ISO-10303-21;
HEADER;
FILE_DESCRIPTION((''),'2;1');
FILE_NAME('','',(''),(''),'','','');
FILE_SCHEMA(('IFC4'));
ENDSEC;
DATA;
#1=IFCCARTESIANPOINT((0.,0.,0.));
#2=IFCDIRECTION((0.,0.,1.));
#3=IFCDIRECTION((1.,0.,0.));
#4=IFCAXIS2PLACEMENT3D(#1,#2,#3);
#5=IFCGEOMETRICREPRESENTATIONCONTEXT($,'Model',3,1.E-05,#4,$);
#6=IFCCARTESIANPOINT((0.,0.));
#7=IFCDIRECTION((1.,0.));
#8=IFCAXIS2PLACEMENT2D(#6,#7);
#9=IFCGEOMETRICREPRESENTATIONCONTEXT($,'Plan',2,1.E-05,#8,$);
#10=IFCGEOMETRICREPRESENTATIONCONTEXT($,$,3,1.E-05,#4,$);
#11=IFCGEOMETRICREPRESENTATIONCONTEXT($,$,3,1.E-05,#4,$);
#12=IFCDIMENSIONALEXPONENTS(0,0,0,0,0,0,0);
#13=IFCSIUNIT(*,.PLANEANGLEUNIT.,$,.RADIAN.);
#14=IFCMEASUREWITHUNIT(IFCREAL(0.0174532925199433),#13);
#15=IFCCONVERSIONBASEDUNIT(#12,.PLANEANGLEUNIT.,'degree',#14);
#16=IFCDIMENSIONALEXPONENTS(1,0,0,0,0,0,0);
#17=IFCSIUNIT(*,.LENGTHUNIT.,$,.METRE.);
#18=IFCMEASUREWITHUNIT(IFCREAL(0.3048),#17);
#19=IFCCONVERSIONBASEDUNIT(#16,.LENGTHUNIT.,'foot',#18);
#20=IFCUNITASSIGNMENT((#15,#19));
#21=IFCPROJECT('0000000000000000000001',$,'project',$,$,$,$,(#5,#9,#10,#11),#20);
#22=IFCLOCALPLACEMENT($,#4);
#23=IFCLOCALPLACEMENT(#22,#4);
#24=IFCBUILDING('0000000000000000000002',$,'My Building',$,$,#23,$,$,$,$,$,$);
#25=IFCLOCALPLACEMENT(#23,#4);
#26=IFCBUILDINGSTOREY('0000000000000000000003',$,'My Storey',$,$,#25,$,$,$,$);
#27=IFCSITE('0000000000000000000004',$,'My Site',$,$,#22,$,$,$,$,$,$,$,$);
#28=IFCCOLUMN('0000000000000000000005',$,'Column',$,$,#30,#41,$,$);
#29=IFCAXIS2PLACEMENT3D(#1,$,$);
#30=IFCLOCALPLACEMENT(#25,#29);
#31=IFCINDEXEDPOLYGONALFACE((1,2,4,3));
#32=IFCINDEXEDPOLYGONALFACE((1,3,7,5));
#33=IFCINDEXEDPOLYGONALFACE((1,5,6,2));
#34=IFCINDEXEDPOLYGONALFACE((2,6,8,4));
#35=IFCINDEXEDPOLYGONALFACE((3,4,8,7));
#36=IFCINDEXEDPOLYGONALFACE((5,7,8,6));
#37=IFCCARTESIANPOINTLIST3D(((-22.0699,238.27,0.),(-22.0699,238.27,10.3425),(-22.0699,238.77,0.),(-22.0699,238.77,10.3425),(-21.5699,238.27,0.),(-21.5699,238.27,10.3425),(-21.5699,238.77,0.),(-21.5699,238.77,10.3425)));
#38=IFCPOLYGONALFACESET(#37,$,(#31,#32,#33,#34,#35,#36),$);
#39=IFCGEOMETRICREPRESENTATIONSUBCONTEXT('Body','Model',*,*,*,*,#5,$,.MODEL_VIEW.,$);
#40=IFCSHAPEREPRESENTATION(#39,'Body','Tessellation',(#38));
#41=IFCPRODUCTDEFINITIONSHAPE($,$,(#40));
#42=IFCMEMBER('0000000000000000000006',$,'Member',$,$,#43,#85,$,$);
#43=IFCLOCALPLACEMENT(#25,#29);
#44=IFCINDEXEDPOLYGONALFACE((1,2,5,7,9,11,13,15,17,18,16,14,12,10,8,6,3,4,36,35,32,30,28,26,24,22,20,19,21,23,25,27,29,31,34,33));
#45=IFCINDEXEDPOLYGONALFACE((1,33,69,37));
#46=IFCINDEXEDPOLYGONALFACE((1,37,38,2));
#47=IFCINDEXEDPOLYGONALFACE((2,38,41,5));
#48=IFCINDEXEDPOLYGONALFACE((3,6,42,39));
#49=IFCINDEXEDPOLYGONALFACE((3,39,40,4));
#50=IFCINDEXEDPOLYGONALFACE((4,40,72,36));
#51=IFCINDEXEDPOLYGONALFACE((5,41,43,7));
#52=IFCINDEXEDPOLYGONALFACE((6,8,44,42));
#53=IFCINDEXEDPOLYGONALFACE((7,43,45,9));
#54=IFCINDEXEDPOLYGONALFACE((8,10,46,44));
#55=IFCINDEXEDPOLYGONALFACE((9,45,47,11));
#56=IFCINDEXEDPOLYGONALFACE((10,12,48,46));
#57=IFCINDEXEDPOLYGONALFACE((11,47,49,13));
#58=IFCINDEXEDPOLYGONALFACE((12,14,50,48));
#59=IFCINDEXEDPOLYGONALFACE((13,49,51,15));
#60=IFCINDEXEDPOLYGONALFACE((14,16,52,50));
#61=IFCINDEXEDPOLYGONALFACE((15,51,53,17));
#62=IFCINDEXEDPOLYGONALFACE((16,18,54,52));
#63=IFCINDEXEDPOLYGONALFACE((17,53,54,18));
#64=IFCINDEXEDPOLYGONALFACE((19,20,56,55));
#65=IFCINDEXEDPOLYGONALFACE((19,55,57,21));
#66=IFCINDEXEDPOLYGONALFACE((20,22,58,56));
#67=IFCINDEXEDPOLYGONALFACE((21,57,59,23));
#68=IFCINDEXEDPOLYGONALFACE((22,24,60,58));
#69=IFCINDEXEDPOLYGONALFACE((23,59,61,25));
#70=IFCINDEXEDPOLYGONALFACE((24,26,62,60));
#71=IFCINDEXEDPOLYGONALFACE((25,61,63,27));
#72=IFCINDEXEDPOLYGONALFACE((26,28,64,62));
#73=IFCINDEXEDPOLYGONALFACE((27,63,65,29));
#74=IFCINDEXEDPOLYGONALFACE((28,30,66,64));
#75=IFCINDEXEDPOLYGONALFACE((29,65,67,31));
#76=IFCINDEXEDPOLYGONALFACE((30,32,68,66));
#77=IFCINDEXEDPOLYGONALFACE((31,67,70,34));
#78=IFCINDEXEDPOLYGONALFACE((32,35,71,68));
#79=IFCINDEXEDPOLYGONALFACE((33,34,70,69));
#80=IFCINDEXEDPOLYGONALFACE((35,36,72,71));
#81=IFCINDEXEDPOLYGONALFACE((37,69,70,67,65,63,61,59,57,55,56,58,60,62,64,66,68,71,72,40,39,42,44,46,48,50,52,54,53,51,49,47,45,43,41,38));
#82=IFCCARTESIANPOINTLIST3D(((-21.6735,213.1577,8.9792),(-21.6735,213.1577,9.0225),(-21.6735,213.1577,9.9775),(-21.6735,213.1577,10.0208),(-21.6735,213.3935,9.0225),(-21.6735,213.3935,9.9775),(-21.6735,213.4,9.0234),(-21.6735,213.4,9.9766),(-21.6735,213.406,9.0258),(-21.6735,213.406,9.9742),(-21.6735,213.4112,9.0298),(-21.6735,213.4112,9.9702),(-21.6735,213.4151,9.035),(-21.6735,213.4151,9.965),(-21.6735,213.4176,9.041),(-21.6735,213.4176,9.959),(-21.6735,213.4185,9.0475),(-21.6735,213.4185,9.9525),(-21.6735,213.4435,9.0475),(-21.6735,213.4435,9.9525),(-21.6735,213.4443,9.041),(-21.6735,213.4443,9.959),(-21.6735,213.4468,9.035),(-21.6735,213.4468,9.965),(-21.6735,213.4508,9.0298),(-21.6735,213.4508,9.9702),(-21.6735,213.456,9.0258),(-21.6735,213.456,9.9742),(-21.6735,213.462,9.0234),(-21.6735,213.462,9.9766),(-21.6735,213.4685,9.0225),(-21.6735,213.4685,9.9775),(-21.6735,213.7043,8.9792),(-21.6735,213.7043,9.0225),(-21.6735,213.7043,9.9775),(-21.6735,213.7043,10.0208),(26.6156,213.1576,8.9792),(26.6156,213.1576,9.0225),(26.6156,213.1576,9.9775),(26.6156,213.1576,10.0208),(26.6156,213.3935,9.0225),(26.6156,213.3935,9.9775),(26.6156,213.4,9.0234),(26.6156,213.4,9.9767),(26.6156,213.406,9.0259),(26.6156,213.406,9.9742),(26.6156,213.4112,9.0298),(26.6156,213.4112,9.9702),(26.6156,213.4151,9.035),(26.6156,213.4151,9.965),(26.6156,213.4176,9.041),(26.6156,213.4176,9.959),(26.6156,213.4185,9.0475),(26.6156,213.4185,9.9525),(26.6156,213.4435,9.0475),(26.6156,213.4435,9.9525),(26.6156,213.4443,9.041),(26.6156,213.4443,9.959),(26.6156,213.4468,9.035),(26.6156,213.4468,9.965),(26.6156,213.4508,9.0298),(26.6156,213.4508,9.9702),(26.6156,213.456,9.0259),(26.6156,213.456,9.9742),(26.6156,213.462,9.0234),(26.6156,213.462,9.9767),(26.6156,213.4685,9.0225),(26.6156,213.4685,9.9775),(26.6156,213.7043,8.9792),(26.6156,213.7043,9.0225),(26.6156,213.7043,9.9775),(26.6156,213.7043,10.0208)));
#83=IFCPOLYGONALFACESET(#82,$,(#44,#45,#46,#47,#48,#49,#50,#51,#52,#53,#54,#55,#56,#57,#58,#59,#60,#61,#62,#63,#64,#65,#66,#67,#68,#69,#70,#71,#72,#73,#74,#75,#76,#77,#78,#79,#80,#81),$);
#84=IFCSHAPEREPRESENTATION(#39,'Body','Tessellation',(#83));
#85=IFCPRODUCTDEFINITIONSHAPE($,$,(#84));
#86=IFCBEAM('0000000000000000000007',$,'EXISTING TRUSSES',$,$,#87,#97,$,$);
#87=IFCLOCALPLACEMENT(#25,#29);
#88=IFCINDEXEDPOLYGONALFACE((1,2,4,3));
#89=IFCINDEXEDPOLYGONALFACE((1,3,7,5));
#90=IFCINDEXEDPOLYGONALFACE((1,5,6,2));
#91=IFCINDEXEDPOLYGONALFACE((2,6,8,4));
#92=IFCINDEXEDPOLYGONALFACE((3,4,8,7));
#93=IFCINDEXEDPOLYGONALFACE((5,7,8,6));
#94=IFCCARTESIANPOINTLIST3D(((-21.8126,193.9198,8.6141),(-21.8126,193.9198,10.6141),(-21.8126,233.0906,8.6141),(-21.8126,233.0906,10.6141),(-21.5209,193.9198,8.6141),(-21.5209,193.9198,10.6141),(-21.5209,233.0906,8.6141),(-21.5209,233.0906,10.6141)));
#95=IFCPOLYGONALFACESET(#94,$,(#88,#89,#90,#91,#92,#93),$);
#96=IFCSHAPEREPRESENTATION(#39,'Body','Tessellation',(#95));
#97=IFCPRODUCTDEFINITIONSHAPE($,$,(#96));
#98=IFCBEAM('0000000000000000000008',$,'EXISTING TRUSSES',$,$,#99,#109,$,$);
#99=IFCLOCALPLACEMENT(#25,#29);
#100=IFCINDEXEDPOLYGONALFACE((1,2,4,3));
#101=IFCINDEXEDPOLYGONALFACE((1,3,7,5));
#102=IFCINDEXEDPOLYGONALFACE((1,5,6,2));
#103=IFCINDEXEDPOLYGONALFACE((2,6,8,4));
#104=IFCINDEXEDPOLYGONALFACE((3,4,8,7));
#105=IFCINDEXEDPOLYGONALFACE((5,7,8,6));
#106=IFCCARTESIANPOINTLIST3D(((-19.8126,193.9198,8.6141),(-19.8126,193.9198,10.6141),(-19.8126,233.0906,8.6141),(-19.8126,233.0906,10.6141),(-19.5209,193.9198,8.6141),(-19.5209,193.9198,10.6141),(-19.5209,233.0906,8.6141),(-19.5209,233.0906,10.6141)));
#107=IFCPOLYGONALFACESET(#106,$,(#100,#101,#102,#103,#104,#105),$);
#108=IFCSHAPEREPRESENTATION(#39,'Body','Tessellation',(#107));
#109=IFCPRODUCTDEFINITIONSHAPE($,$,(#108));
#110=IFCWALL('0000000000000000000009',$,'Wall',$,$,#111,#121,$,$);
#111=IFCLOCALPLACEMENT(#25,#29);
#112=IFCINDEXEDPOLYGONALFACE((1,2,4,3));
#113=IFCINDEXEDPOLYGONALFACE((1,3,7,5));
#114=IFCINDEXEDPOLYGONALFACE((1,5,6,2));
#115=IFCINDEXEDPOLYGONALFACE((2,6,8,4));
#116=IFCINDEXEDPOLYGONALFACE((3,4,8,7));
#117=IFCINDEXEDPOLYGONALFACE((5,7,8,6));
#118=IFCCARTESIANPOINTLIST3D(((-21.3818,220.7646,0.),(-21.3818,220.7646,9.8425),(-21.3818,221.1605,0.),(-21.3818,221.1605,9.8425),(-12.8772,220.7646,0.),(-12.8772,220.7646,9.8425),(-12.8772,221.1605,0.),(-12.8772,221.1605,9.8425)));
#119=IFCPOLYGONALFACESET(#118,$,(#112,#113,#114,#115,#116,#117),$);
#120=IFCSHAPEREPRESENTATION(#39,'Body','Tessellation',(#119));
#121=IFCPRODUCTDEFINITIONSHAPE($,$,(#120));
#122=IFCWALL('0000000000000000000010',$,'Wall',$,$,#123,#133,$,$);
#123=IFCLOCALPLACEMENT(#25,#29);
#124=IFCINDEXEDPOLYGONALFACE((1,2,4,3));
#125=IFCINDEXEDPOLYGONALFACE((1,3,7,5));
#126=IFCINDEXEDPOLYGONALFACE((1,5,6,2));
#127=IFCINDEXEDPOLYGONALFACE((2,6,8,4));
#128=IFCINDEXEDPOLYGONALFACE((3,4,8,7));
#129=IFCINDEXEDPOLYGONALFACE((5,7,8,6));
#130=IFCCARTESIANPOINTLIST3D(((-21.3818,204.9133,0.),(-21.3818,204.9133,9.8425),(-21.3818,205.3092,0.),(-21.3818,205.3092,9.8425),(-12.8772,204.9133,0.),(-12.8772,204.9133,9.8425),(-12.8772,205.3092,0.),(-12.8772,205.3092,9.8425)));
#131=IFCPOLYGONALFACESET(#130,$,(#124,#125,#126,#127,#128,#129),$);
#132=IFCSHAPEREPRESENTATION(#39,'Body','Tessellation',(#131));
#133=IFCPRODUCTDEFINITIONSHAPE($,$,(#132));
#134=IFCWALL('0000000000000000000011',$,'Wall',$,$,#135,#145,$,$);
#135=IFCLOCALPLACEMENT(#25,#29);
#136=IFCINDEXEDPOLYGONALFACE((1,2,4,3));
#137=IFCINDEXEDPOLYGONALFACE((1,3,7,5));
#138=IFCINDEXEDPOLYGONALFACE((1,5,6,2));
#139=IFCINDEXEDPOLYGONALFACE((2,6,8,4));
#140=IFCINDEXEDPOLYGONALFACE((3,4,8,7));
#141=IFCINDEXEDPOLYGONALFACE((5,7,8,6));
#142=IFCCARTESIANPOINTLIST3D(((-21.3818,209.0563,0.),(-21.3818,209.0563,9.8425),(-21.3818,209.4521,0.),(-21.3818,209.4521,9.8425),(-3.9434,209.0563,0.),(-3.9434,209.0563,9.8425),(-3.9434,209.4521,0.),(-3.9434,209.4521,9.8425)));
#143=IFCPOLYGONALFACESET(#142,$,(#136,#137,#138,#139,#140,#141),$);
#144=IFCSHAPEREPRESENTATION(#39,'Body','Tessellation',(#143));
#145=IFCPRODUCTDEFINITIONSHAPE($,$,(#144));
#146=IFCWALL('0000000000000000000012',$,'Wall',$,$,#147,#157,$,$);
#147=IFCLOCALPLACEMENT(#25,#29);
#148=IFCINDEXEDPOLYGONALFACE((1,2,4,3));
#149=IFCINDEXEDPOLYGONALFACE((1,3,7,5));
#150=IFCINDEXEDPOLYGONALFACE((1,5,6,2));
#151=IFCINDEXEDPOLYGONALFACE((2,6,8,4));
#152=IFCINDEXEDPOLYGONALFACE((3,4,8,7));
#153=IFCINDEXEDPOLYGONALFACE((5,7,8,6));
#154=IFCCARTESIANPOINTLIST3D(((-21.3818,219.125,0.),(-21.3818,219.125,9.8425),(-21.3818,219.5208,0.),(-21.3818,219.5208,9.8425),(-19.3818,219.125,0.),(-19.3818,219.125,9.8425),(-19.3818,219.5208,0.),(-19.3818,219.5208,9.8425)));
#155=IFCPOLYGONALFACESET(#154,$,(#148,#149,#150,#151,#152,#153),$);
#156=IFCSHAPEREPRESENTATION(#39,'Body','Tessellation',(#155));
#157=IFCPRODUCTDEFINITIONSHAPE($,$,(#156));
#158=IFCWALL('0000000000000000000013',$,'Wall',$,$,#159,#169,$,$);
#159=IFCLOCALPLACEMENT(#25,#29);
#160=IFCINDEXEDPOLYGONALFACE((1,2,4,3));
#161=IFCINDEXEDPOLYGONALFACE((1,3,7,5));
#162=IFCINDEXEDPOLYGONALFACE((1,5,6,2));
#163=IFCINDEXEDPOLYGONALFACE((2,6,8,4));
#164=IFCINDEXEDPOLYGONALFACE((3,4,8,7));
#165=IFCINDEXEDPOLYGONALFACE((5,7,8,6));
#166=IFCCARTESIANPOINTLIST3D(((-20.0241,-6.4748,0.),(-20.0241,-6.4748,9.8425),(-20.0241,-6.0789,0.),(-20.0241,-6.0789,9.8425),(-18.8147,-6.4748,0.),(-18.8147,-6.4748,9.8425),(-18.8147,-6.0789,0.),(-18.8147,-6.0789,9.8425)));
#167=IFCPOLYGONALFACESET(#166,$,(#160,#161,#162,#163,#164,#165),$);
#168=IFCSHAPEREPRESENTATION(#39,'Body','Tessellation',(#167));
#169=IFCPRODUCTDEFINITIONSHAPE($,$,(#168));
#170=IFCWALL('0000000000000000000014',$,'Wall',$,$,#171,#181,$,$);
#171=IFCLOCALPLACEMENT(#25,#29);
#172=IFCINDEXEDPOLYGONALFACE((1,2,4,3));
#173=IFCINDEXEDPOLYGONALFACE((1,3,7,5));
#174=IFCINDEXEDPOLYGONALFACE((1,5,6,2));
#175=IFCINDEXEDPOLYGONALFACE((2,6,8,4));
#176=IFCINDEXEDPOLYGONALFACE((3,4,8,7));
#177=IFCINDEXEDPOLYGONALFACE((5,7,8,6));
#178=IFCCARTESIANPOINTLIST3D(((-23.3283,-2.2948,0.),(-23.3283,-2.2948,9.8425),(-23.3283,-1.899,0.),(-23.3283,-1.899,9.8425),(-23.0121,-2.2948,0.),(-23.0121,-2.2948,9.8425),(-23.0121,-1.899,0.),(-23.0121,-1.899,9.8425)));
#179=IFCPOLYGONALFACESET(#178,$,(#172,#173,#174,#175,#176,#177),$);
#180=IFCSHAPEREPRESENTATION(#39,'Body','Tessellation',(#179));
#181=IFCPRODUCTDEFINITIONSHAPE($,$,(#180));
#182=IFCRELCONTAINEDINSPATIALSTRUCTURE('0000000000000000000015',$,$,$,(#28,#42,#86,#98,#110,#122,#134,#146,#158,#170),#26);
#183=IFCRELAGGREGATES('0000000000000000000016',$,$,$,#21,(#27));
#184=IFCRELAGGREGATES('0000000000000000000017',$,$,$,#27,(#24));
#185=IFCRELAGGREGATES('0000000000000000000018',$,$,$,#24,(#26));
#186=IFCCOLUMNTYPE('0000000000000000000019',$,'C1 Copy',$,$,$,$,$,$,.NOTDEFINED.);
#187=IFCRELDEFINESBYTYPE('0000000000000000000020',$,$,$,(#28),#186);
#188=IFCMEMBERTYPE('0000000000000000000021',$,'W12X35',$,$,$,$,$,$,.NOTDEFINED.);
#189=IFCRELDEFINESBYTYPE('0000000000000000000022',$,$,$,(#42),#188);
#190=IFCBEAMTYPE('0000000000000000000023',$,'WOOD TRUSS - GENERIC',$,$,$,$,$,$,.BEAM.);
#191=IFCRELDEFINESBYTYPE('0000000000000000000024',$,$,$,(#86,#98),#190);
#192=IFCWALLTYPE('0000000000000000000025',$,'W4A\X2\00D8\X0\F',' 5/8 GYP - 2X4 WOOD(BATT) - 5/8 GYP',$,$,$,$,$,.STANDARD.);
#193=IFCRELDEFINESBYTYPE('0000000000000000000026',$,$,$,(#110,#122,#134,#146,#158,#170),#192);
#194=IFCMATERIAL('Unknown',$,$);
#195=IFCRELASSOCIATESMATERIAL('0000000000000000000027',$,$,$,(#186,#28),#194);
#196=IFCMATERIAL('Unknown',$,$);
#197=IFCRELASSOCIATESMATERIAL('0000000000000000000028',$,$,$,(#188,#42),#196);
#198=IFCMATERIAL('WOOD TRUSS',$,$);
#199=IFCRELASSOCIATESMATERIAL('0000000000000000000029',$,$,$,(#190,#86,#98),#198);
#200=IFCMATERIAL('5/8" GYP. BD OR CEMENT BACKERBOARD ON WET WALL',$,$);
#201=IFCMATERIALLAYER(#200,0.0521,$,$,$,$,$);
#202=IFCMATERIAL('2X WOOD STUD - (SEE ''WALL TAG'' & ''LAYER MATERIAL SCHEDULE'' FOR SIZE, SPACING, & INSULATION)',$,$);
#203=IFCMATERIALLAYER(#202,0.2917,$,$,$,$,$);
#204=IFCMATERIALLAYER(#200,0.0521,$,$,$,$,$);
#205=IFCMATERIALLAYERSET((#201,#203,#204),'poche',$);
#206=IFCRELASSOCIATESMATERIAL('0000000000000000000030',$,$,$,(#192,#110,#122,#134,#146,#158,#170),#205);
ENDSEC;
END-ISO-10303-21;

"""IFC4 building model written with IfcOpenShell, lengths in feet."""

from ifc_helpers import new_model, entity, si_unit, converted_unit, frame, origin_with_axes, origin_2d_with_axis, place, context, subcontext, project, spatial, indexed_curve, rectangle, i_section, outline, extrude, material, layer, layer_set, layer_usage, material_profile, profile_set, profile_usage, type_object, element, save


model = new_model("IFC4")

# Units and contexts
model_context = context("Model", 3, precision=1e-05, world=origin_with_axes())
plan_context = context("Plan", 2, precision=1e-05, world=origin_2d_with_axis())
context_of_model_1 = context(None, 3, precision=1e-05, world=origin_with_axes())
context_of_model_2 = context(None, 3, precision=1e-05, world=origin_with_axes())
body_context = subcontext(model_context, "Body", "Model", "MODEL_VIEW")
ifc_project = project(units=[converted_unit("PLANEANGLEUNIT", "degree", entity("IfcReal", 0.0174532925199433), si_unit("PLANEANGLEUNIT", "RADIAN"), dimensions=[0, 0, 0, 0, 0, 0, 0]), converted_unit("LENGTHUNIT", "foot", entity("IfcReal", 0.3048), si_unit("LENGTHUNIT", "METRE"), dimensions=[1, 0, 0, 0, 0, 0, 0])], contexts=[model_context, plan_context, context_of_model_1, context_of_model_2])

# Site, building, storey
site_placement = place(None, origin_with_axes())
site = spatial("IfcSite", under=ifc_project, at=site_placement, Name="My Site")
building_placement = place(site_placement, origin_with_axes())
building = spatial("IfcBuilding", under=site, at=building_placement, Name="My Building")
storey_placement = place(building_placement, origin_with_axes())
storey = spatial("IfcBuildingStorey", under=building, at=storey_placement, Name="My Storey")

# Column
ifc_material_1 = material(Name="Unknown")
ifc_material_profile_1 = material_profile(ifc_material_1, rectangle(XDim=0.5, YDim=0.5))
ifc_profile_set_1 = profile_set([ifc_material_profile_1])
ifc_profile_usage_1 = profile_usage(ifc_profile_set_1, cardinal=5)
column_type = type_object("IfcColumnType", Name="C1 Copy", PredefinedType="NOTDEFINED", material=ifc_profile_set_1)
column_placement = place(storey_placement, frame((-21.8199, 238.52, 0.0), z_axis=(0.0, 0.0, 1.0), x_axis=(1.0, 0.0, 0.0)))
element("IfcColumn", 1, at=column_placement, inside=storey, type_object=column_type, material=ifc_profile_usage_1, Name="Column", context=body_context, shape_type="SweptSolid", body=[
    extrude(rectangle(XDim=0.5, YDim=0.5), origin_with_axes(), (0.0, 0.0, 1.0), 10.3425),
])

# Member
ifc_material_2 = material(Name="Unknown")
ifc_material_profile_2 = material_profile(ifc_material_2, i_section(OverallWidth=0.5467, OverallDepth=1.0417, WebThickness=0.025, FlangeThickness=0.0433, FilletRadius=0.025))
ifc_profile_set_2 = profile_set([ifc_material_profile_2])
ifc_profile_usage_2 = profile_usage(ifc_profile_set_2, cardinal=5)
member_type = type_object("IfcMemberType", Name="W12X35", PredefinedType="NOTDEFINED", material=ifc_profile_set_2)
member_placement = place(storey_placement, frame((-21.6735, 213.431, 9.5), z_axis=(1.0, 0.0, 0.0), x_axis=(0.0, 1.0, 0.0)))
element("IfcMember", 2, at=member_placement, inside=storey, type_object=member_type, material=ifc_profile_usage_2, Name="Member", context=body_context, shape_type="SweptSolid", body=[
    extrude(i_section(OverallWidth=0.5467, OverallDepth=1.0417, WebThickness=0.025, FlangeThickness=0.0433, FilletRadius=0.025), origin_with_axes(), (0.0, 0.0, 1.0), 48.2891),
])

# Beams
ifc_material_3 = material(Name="WOOD TRUSS")
ifc_material_profile_3 = material_profile(ifc_material_3, rectangle(XDim=0.2917, YDim=2.0))
ifc_profile_set_3 = profile_set([ifc_material_profile_3])
ifc_profile_usage_3 = profile_usage(ifc_profile_set_3, cardinal=5)
beam_type = type_object("IfcBeamType", Name="WOOD TRUSS - GENERIC", PredefinedType="BEAM", material=ifc_profile_set_3)
beam_1_placement = place(storey_placement, frame((-21.6667, 193.9198, 9.6141), z_axis=(0.0, 1.0, 0.0), x_axis=(-1.0, 0.0, 0.0)))
element("IfcBeam", 3, at=beam_1_placement, inside=storey, type_object=beam_type, material=ifc_profile_usage_3, Name="EXISTING TRUSSES", context=body_context, shape_type="SweptSolid", body=[
    extrude(rectangle(XDim=0.2917, YDim=2.0), origin_with_axes(), (0.0, 0.0, 1.0), 39.1707),
])
ifc_profile_usage_4 = profile_usage(ifc_profile_set_3, cardinal=5)
beam_2_placement = place(storey_placement, frame((-19.6667, 193.9198, 9.6141), z_axis=(0.0, 1.0, 0.0), x_axis=(-1.0, 0.0, 0.0)))
element("IfcBeam", 4, at=beam_2_placement, inside=storey, type_object=beam_type, material=ifc_profile_usage_4, Name="EXISTING TRUSSES", context=body_context, shape_type="SweptSolid", body=[
    extrude(rectangle(XDim=0.2917, YDim=2.0), origin_with_axes(), (0.0, 0.0, 1.0), 39.1707),
])

# Walls
ifc_material_4 = material(Name="5/8\" GYP. BD OR CEMENT BACKERBOARD ON WET WALL")
ifc_layer_1 = layer(ifc_material_4, 0.0521)
ifc_material_5 = material(Name="2X WOOD STUD - (SEE 'WALL TAG' & 'LAYER MATERIAL SCHEDULE' FOR SIZE, SPACING, & INSULATION)")
ifc_layer_2 = layer(ifc_material_5, 0.2917)
ifc_layer_3 = layer(ifc_material_4, 0.0521)
ifc_layer_set_1 = layer_set([ifc_layer_1, ifc_layer_2, ifc_layer_3], Name="poche")
ifc_layer_usage_1 = layer_usage(ifc_layer_set_1, "AXIS2", "POSITIVE", 0.0)
wall_type_1 = type_object("IfcWallType", Name="W4AØF", Description=" 5/8 GYP - 2X4 WOOD(BATT) - 5/8 GYP", PredefinedType="STANDARD", material=ifc_layer_set_1)
wall_1_placement = place(storey_placement, frame((-21.3818, 220.7646, 0.0), z_axis=(0.0, 0.0, 1.0), x_axis=(1.0, 0.0, 0.0)))
element("IfcWall", 5, at=wall_1_placement, inside=storey, type_object=wall_type_1, material=ifc_layer_usage_1, Name="Wall", context=body_context, shape_type="SweptSolid", body=[
    extrude(outline(indexed_curve([(0.0, 0.0), (0.0, 0.3958), (8.5047, 0.3958), (8.5047, 0.0), (0.0, 0.0)], self_intersect=False)), origin_with_axes(), (0.0, 0.0, 1.0), 9.8425),
])
ifc_layer_usage_2 = layer_usage(ifc_layer_set_1, "AXIS2", "POSITIVE", 0.0)
wall_2_placement = place(storey_placement, frame((-21.3818, 204.9133, 0.0), z_axis=(0.0, 0.0, 1.0), x_axis=(1.0, 0.0, 0.0)))
element("IfcWall", 6, at=wall_2_placement, inside=storey, type_object=wall_type_1, material=ifc_layer_usage_2, Name="Wall", context=body_context, shape_type="SweptSolid", body=[
    extrude(outline(indexed_curve([(0.0, 0.0), (0.0, 0.3958), (8.5046, 0.3958), (8.5046, 0.0), (0.0, 0.0)], self_intersect=False)), origin_with_axes(), (0.0, 0.0, 1.0), 9.8425),
])
ifc_layer_usage_3 = layer_usage(ifc_layer_set_1, "AXIS2", "POSITIVE", 0.0)
wall_3_placement = place(storey_placement, frame((-21.3818, 209.0563, 0.0), z_axis=(0.0, 0.0, 1.0), x_axis=(1.0, -0.000001, 0.0)))
element("IfcWall", 7, at=wall_3_placement, inside=storey, type_object=wall_type_1, material=ifc_layer_usage_3, Name="Wall", context=body_context, shape_type="SweptSolid", body=[
    extrude(outline(indexed_curve([(0.0, 0.0), (0.0, 0.3958), (17.4385, 0.3958), (17.4385, 0.0), (0.0, 0.0)], self_intersect=False)), origin_with_axes(), (0.0, 0.0, 1.0), 9.8425),
])
ifc_layer_usage_4 = layer_usage(ifc_layer_set_1, "AXIS2", "POSITIVE", 0.0)
wall_4_placement = place(storey_placement, frame((-21.3818, 219.125, 0.0), z_axis=(0.0, 0.0, 1.0), x_axis=(1.0, -0.000001, 0.0)))
element("IfcWall", 8, at=wall_4_placement, inside=storey, type_object=wall_type_1, material=ifc_layer_usage_4, Name="Wall", context=body_context, shape_type="SweptSolid", body=[
    extrude(outline(indexed_curve([(0.0, 0.0), (0.0, 0.3958), (2.0, 0.3958), (2.0, 0.0), (0.0, 0.0)], self_intersect=False)), origin_with_axes(), (0.0, 0.0, 1.0), 9.8425),
])
ifc_layer_usage_5 = layer_usage(ifc_layer_set_1, "AXIS2", "POSITIVE", 0.0)
wall_5_placement = place(storey_placement, frame((-20.0241, -6.4748, 0.0), z_axis=(0.0, 0.0, 1.0), x_axis=(1.0, 0.0, 0.0)))
element("IfcWall", 9, at=wall_5_placement, inside=storey, type_object=wall_type_1, material=ifc_layer_usage_5, Name="Wall", context=body_context, shape_type="SweptSolid", body=[
    extrude(outline(indexed_curve([(0.0, 0.0), (0.0, 0.3958), (1.2093, 0.3958), (1.2093, 0.0), (0.0, 0.0)], self_intersect=False)), origin_with_axes(), (0.0, 0.0, 1.0), 9.8425),
])

# Wall
ifc_layer_usage_6 = layer_usage(ifc_layer_set_1, "AXIS2", "POSITIVE", 0.0)
wall_6_placement = place(storey_placement, frame((-23.3283, -2.2948, 0.0), z_axis=(0.0, 0.0, 1.0), x_axis=(1.0, 0.0, 0.0)))
element("IfcWall", 10, at=wall_6_placement, inside=storey, type_object=wall_type_1, material=ifc_layer_usage_6, Name="Wall", context=body_context, shape_type="SweptSolid", body=[
    extrude(outline(indexed_curve([(0.0, 0.0), (0.0, 0.3958), (0.3162, 0.3958), (0.3162, 0.0), (0.0, 0.0)], self_intersect=False)), origin_with_axes(), (0.0, 0.0, 1.0), 9.8425),
])

save(model, "model.ifc")
